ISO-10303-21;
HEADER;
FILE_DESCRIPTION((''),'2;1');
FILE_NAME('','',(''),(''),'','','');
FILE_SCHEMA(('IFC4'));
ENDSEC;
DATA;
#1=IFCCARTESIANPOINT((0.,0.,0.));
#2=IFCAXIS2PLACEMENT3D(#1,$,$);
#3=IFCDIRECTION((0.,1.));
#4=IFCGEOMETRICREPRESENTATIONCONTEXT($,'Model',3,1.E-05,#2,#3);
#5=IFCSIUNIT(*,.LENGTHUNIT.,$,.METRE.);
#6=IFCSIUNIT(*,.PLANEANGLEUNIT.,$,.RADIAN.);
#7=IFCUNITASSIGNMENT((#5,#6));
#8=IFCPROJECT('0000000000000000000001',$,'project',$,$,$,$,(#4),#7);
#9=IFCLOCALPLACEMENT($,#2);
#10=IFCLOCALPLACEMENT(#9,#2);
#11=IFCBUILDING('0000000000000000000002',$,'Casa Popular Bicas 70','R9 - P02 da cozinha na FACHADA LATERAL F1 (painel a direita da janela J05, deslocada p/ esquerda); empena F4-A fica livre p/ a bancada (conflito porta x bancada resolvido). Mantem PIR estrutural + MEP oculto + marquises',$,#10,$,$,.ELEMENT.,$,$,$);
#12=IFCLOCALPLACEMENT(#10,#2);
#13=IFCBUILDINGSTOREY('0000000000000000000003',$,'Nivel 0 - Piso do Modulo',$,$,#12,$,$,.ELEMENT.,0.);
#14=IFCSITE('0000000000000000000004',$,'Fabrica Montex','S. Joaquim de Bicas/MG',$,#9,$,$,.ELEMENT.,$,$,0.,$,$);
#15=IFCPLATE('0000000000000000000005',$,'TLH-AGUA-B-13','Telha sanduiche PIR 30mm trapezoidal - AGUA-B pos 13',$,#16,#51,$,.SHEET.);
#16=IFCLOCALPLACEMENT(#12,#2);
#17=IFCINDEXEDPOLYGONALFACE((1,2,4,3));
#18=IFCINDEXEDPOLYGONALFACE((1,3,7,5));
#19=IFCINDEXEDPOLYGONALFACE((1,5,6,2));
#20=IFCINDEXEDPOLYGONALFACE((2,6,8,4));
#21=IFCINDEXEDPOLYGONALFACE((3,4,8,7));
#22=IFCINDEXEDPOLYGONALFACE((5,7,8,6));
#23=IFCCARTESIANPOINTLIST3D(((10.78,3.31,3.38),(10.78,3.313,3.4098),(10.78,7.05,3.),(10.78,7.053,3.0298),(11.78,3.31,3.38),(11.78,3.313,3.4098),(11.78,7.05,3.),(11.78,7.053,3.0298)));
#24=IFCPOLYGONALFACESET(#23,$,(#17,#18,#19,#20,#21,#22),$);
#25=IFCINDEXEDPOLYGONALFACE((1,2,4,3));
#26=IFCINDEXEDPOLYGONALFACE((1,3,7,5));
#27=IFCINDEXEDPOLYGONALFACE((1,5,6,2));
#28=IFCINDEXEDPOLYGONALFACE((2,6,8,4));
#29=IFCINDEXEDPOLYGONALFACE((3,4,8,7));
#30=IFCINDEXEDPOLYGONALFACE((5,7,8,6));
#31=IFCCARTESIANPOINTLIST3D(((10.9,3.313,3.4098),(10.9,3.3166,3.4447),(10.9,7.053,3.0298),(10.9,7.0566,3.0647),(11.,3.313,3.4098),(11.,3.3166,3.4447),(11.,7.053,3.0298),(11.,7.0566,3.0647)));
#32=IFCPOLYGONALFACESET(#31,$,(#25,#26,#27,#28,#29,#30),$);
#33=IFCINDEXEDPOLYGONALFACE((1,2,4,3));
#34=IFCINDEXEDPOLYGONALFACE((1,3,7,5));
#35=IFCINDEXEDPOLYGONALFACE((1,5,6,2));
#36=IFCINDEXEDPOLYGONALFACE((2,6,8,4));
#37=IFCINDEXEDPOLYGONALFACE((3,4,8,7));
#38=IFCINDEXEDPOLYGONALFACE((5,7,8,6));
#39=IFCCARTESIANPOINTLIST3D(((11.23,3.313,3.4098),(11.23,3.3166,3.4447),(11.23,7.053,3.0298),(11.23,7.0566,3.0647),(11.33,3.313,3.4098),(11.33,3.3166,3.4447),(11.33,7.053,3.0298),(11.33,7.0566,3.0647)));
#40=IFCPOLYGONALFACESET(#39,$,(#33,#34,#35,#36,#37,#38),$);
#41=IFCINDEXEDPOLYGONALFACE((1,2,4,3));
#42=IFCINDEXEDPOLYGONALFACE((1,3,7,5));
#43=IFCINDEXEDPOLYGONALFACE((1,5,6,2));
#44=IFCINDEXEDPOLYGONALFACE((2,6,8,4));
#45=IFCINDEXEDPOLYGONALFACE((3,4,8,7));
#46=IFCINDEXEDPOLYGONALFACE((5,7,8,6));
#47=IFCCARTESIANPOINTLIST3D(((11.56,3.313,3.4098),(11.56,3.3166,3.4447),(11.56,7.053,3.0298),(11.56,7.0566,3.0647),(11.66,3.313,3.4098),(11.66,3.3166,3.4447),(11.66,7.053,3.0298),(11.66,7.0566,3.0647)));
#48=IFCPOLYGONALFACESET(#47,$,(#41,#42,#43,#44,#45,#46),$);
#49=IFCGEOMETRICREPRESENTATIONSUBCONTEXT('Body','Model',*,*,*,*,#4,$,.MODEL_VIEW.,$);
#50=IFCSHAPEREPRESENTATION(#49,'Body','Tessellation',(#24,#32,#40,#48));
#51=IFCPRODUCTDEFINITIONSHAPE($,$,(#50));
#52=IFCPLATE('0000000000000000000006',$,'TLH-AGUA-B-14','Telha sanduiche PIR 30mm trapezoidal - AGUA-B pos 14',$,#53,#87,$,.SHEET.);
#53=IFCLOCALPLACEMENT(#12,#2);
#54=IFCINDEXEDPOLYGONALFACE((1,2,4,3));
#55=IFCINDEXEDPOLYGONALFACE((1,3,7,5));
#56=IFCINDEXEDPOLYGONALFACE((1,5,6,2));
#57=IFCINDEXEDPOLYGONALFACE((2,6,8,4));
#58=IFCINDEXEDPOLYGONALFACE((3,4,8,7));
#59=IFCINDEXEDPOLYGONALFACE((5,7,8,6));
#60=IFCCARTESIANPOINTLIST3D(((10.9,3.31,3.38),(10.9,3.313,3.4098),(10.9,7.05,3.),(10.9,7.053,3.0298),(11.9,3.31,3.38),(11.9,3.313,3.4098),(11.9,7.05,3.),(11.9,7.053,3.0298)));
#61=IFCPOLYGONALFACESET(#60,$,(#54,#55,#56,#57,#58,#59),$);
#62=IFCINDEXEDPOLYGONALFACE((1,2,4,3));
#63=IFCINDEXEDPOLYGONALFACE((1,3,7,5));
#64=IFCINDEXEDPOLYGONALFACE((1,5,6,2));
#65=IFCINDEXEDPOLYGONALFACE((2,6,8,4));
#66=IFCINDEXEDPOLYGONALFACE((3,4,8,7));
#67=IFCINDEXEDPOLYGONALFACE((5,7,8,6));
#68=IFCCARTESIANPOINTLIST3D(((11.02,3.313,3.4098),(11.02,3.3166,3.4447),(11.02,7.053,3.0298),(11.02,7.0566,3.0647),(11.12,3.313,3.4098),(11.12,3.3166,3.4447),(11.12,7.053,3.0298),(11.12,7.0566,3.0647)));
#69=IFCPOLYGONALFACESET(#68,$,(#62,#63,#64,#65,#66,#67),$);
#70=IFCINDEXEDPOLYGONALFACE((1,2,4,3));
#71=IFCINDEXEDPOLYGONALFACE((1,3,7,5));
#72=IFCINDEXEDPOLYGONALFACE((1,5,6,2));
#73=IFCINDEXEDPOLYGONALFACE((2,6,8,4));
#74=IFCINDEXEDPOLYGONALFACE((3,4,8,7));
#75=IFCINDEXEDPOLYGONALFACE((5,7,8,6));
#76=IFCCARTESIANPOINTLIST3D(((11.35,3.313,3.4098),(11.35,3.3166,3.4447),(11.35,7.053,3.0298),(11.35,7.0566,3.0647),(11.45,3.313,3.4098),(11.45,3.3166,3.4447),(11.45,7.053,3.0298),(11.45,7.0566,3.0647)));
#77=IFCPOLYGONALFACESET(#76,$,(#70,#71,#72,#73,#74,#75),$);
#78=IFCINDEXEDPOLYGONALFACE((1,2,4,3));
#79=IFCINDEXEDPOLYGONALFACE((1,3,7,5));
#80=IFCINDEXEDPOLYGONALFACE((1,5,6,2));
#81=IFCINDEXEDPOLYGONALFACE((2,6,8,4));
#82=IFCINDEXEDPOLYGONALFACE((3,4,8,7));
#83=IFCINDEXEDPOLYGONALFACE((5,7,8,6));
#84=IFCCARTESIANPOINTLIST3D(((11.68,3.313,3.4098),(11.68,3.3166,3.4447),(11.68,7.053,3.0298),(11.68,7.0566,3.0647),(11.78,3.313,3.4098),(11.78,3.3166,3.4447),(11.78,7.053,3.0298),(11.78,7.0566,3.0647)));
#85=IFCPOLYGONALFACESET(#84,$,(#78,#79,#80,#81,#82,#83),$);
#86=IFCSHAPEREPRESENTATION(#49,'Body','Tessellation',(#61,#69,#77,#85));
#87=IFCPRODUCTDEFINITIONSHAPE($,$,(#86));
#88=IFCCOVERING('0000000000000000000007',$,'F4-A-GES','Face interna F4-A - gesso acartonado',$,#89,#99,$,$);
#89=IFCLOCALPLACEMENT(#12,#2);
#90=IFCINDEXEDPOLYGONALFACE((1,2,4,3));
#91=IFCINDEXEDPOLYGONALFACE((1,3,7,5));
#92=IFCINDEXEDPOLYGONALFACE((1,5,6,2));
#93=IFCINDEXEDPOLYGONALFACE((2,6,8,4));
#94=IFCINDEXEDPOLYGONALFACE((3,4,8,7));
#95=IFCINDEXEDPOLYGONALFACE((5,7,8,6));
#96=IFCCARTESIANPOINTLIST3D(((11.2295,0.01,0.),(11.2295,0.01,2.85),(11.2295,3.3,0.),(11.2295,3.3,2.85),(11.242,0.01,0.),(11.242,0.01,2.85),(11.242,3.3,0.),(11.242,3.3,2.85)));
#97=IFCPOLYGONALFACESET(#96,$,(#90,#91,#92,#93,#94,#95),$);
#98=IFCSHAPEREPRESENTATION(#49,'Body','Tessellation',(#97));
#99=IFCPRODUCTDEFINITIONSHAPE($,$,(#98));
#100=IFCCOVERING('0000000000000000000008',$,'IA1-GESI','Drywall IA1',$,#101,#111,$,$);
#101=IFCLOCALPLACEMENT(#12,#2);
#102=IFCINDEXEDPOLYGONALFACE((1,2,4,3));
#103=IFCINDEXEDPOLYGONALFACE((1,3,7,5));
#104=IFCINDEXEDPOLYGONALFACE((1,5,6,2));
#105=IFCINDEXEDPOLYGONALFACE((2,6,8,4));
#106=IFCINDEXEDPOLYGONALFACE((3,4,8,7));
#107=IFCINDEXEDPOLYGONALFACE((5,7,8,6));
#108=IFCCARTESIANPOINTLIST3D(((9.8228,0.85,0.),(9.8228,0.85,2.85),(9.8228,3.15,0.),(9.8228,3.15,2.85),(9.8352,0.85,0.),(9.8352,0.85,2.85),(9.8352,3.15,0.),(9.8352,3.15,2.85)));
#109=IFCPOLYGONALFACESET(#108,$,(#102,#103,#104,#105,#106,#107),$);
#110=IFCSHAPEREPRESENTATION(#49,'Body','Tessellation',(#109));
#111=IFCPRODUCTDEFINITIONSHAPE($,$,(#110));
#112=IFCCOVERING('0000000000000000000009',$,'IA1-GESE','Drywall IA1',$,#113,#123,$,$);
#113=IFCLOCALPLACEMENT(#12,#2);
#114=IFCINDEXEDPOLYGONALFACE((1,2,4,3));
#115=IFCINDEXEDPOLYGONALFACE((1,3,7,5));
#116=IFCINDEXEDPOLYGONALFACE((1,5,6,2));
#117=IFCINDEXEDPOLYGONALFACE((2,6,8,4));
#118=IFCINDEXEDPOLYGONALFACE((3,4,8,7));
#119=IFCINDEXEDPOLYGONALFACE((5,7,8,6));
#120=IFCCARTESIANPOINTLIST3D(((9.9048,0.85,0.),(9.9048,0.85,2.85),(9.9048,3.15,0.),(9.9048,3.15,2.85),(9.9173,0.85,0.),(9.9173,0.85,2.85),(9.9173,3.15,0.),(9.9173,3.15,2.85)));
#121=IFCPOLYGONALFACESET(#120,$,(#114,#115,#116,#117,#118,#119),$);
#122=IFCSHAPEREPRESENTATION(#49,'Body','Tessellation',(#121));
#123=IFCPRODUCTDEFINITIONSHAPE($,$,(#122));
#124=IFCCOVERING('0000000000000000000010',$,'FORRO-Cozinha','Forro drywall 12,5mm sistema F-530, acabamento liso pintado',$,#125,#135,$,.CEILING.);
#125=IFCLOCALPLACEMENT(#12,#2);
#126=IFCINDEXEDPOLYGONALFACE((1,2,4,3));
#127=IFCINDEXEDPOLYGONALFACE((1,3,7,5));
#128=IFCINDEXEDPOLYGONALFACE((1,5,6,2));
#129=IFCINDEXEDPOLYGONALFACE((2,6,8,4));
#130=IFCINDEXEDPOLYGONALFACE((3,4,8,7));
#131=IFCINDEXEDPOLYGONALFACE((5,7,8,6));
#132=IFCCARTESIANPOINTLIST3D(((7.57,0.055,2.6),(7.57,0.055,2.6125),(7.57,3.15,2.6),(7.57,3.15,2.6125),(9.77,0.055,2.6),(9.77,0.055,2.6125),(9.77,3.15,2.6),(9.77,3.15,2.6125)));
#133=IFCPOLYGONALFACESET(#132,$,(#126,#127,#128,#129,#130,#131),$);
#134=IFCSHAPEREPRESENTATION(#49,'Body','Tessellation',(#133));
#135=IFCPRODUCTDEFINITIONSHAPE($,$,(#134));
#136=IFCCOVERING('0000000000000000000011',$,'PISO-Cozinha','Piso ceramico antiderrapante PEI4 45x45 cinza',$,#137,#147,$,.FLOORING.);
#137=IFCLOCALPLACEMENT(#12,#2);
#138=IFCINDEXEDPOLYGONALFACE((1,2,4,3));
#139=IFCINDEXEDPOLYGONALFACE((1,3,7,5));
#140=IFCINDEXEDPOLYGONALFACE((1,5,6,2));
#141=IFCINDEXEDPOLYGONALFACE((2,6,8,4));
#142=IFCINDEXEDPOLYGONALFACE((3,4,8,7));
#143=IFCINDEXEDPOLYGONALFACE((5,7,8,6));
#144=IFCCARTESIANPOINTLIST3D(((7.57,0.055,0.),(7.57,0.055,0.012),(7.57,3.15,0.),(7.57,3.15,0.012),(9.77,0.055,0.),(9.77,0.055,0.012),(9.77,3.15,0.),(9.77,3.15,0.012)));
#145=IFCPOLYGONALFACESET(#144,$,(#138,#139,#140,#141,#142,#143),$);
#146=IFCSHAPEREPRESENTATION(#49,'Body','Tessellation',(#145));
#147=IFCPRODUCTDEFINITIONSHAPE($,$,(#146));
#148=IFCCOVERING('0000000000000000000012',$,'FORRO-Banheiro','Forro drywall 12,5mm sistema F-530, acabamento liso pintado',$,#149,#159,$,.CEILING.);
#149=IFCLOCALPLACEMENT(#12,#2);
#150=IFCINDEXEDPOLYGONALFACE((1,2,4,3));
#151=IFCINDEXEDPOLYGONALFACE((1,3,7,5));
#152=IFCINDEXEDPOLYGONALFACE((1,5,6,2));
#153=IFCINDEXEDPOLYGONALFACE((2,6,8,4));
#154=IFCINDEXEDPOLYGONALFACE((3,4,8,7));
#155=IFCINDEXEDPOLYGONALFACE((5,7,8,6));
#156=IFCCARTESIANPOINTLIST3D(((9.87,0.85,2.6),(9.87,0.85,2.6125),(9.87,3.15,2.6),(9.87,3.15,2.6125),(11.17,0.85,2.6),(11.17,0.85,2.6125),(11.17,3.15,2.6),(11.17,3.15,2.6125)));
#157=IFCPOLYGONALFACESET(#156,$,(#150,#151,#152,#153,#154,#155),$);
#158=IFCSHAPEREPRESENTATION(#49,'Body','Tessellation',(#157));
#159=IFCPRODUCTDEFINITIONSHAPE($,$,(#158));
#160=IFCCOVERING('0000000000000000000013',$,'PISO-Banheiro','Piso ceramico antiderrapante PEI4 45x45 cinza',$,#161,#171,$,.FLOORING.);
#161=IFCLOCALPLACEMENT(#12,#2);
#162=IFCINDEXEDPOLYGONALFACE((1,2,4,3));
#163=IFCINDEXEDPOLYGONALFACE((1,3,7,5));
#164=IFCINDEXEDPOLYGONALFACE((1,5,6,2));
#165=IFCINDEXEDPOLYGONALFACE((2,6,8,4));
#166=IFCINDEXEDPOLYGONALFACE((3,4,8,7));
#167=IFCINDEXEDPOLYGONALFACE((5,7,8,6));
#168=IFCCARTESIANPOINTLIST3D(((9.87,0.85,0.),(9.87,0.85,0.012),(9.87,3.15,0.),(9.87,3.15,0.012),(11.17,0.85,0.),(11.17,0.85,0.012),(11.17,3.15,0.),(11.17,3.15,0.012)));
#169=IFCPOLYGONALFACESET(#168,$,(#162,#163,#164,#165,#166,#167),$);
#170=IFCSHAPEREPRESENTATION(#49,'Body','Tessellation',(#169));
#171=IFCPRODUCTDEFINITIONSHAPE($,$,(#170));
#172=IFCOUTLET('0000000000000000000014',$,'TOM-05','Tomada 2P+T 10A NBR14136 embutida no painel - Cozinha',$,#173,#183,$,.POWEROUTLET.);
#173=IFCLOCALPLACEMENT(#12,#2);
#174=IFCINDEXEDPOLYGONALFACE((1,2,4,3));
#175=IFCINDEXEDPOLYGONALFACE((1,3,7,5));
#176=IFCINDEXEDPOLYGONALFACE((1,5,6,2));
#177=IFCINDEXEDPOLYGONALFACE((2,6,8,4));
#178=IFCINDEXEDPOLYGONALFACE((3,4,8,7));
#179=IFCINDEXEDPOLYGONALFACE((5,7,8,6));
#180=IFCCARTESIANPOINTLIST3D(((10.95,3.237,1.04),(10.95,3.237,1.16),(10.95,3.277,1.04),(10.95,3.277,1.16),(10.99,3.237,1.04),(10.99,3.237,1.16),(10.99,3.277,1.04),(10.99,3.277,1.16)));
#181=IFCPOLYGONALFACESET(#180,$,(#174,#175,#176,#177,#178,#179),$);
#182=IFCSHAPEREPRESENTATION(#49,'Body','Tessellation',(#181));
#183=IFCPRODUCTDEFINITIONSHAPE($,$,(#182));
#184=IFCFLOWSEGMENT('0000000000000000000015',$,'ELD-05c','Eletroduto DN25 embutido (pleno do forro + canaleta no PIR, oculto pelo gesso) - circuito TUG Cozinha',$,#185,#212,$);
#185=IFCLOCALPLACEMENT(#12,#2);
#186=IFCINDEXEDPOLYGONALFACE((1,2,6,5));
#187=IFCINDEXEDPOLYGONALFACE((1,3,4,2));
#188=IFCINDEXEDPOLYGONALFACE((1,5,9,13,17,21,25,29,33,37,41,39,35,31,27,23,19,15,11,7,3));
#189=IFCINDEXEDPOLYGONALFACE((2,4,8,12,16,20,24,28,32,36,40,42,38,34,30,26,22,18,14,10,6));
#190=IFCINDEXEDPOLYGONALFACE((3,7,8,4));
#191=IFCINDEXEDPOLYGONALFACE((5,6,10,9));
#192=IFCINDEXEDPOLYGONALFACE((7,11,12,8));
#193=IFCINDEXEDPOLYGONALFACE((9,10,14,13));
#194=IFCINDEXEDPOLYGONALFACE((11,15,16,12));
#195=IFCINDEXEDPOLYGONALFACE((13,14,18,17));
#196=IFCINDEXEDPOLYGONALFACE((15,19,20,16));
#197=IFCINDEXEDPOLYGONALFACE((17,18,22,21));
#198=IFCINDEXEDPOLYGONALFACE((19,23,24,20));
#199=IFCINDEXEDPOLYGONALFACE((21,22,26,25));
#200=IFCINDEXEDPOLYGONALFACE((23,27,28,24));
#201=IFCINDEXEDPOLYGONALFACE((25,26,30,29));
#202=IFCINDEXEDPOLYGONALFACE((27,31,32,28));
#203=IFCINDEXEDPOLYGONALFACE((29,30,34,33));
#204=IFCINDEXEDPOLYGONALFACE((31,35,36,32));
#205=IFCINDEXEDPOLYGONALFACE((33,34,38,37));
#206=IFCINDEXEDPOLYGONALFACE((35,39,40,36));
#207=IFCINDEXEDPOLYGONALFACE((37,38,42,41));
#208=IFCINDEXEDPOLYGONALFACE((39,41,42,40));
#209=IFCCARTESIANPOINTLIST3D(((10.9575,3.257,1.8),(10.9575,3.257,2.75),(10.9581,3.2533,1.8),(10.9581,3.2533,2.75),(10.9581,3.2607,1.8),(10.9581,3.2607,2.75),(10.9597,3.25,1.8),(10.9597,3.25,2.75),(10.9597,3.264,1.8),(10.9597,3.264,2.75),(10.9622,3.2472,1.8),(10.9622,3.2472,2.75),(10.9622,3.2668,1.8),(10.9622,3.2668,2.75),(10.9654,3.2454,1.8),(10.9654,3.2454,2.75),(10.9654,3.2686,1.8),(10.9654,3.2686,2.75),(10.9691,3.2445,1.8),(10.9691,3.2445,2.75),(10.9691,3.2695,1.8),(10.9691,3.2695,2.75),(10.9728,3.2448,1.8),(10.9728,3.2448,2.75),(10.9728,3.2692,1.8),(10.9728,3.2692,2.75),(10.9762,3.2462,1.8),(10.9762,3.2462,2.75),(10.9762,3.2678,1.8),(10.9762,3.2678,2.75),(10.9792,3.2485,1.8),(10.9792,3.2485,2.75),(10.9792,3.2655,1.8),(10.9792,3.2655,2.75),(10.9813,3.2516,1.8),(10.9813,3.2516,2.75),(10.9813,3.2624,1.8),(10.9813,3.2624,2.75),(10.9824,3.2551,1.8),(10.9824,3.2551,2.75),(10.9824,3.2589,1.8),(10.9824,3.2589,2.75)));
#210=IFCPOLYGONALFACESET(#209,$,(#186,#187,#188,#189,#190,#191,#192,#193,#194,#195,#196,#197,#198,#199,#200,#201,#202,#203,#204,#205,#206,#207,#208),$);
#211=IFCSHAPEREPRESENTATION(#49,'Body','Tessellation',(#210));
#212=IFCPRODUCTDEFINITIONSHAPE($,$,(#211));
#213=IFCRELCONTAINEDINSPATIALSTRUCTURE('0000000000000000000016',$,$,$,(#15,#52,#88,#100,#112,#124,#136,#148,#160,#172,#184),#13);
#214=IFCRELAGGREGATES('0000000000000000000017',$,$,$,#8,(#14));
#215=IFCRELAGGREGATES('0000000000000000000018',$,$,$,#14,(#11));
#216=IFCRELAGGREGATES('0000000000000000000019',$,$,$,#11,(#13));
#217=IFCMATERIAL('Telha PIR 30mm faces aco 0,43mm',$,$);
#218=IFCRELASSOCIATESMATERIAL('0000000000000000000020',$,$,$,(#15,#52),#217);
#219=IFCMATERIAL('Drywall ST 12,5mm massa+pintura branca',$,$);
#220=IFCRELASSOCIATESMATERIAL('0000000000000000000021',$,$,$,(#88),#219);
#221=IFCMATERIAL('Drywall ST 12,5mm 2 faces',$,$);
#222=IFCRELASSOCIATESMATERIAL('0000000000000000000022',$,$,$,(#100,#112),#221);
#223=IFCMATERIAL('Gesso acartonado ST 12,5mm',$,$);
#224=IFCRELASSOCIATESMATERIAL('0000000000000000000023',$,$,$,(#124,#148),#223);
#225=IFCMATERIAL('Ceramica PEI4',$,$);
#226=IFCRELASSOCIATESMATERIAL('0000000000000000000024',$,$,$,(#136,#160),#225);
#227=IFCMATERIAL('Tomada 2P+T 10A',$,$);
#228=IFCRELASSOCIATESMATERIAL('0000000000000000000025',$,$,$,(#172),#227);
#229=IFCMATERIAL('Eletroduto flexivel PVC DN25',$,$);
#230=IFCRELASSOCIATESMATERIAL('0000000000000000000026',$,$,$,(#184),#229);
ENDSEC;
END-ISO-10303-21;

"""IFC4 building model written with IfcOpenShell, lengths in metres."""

from ifc_helpers import new_model, si_unit, direction, frame, frame_2d, origin, origin_2d, place, context, subcontext, project, spatial, rectangle, circle, extrude, material, element, save


model = new_model("IFC4")

# Units and contexts
model_context = context("Model", 3, precision=1e-05, world=origin(), true_north=direction((0.0, 1.0)))
body_context = subcontext(model_context, "Body", "Model", "MODEL_VIEW")
ifc_project = project(units=[si_unit("LENGTHUNIT", "METRE"), si_unit("PLANEANGLEUNIT", "RADIAN")], contexts=[model_context])

# Site, building, storey
site_placement = place(None, origin())
site = spatial("IfcSite", under=ifc_project, at=site_placement, Name="Fabrica Montex", Description="S. Joaquim de Bicas/MG", CompositionType="ELEMENT", RefElevation=0.0)
building_placement = place(site_placement, origin())
building = spatial("IfcBuilding", under=site, at=building_placement, Name="Casa Popular Bicas 70", Description="R9 - P02 da cozinha na FACHADA LATERAL F1 (painel a direita da janela J05, deslocada p/ esquerda); empena F4-A fica livre p/ a bancada (conflito porta x bancada resolvido). Mantem PIR estrutural + MEP oculto + marquises", CompositionType="ELEMENT")
storey_placement = place(building_placement, origin())
storey = spatial("IfcBuildingStorey", under=building, at=storey_placement, Name="Nivel 0 - Piso do Modulo", CompositionType="ELEMENT", Elevation=0.0)

# Plates
ifc_material_1 = material(Name="Telha PIR 30mm faces aco 0,43mm")
for number, where, z_axis, x_axis, name, description in (
    (1, (10.78, 3.31, 3.38), (0.0, 0.101084, 0.994878), (1.0, 0.0, 0.0), "TLH-AGUA-B-13", "Telha sanduiche PIR 30mm trapezoidal - AGUA-B pos 13"),
    (2, (10.9, 3.31, 3.38), (0.0, 0.101084, 0.994878), (1.0, 0.0, 0.0), "TLH-AGUA-B-14", "Telha sanduiche PIR 30mm trapezoidal - AGUA-B pos 14"),
):
    element("IfcPlate", number, at=place(storey_placement, frame(where, z_axis=z_axis, x_axis=x_axis)), inside=storey, material=ifc_material_1, Name=name, Description=description, PredefinedType="SHEET", context=body_context, shape_type="SweptSolid", body=[
        extrude(rectangle(XDim=1.0, YDim=3.7593, at=frame_2d((0.5, 1.8796))), origin(), (0.0, 0.0, 1.0), 0.03),
        extrude(rectangle(XDim=0.1, YDim=3.7593, at=frame_2d((0.17, 1.8796))), frame((0.0, 0.0, 0.03)), (0.0, 0.0, 1.0), 0.035),
        extrude(rectangle(XDim=0.1, YDim=3.7593, at=frame_2d((0.5, 1.8796))), frame((0.0, 0.0, 0.03)), (0.0, 0.0, 1.0), 0.035),
        extrude(rectangle(XDim=0.1, YDim=3.7593, at=frame_2d((0.83, 1.8796))), frame((0.0, 0.0, 0.03)), (0.0, 0.0, 1.0), 0.035),
    ])

# Coverings
ifc_material_2 = material(Name="Drywall ST 12,5mm massa+pintura branca")
covering_1_placement = place(None, frame((11.2357, 3.3, 0.0), z_axis=(0.0, 0.0, 1.0), x_axis=(0.0, -1.0, 0.0)))
element("IfcCovering", 3, at=covering_1_placement, inside=storey, material=ifc_material_2, Name="F4-A-GES", Description="Face interna F4-A - gesso acartonado", context=body_context, shape_type="SweptSolid", body=[
    extrude(rectangle(XDim=3.29, YDim=0.0125, at=frame_2d((1.645, 0.0))), origin(), (0.0, 0.0, 1.0), 2.85),
])
ifc_material_3 = material(Name="Drywall ST 12,5mm 2 faces")
for number, where, z_axis, x_axis, name in (
    (4, (9.829, 3.15, 0.0), (0.0, 0.0, 1.0), (0.0, -1.0, 0.0), "IA1-GESI"),
    (5, (9.911, 3.15, 0.0), (0.0, 0.0, 1.0), (0.0, -1.0, 0.0), "IA1-GESE"),
):
    element("IfcCovering", number, at=place(None, frame(where, z_axis=z_axis, x_axis=x_axis)), inside=storey, material=ifc_material_3, Name=name, Description="Drywall IA1", context=body_context, shape_type="SweptSolid", body=[
        extrude(rectangle(XDim=2.3, YDim=0.0125, at=frame_2d((1.15, 0.0))), origin(), (0.0, 0.0, 1.0), 2.85),
    ])
ifc_material_4 = material(Name="Gesso acartonado ST 12,5mm")
covering_2_placement = place(None, frame((9.77, 3.15, 2.6), z_axis=(0.0, 0.0, 1.0), x_axis=(-1.0, 0.0, 0.0)))
element("IfcCovering", 6, at=covering_2_placement, inside=storey, material=ifc_material_4, Name="FORRO-Cozinha", Description="Forro drywall 12,5mm sistema F-530, acabamento liso pintado", PredefinedType="CEILING", context=body_context, shape_type="SweptSolid", body=[
    extrude(rectangle(XDim=2.2, YDim=3.095, at=frame_2d((1.1, 1.5475))), origin(), (0.0, 0.0, 1.0), 0.0125),
])
ifc_material_5 = material(Name="Ceramica PEI4")
covering_3_placement = place(None, frame((9.77, 3.15, 0.0), z_axis=(0.0, 0.0, 1.0), x_axis=(-1.0, 0.0, 0.0)))
element("IfcCovering", 7, at=covering_3_placement, inside=storey, material=ifc_material_5, Name="PISO-Cozinha", Description="Piso ceramico antiderrapante PEI4 45x45 cinza", PredefinedType="FLOORING", context=body_context, shape_type="SweptSolid", body=[
    extrude(rectangle(XDim=2.2, YDim=3.095, at=frame_2d((1.1, 1.5475))), origin(), (0.0, 0.0, 1.0), 0.012),
])
covering_4_placement = place(None, frame((11.17, 3.15, 2.6), z_axis=(0.0, 0.0, 1.0), x_axis=(-1.0, 0.0, 0.0)))
element("IfcCovering", 8, at=covering_4_placement, inside=storey, material=ifc_material_4, Name="FORRO-Banheiro", Description="Forro drywall 12,5mm sistema F-530, acabamento liso pintado", PredefinedType="CEILING", context=body_context, shape_type="SweptSolid", body=[
    extrude(rectangle(XDim=1.3, YDim=2.3, at=frame_2d((0.65, 1.15))), origin(), (0.0, 0.0, 1.0), 0.0125),
])
covering_5_placement = place(None, frame((11.17, 3.15, 0.0), z_axis=(0.0, 0.0, 1.0), x_axis=(-1.0, 0.0, 0.0)))
element("IfcCovering", 9, at=covering_5_placement, inside=storey, material=ifc_material_5, Name="PISO-Banheiro", Description="Piso ceramico antiderrapante PEI4 45x45 cinza", PredefinedType="FLOORING", context=body_context, shape_type="SweptSolid", body=[
    extrude(rectangle(XDim=1.3, YDim=2.3, at=frame_2d((0.65, 1.15))), origin(), (0.0, 0.0, 1.0), 0.012),
])

# Outlet
ifc_material_6 = material(Name="Tomada 2P+T 10A")
outlet_1_placement = place(None, frame((10.99, 3.277, 1.04), z_axis=(0.0, 0.0, 1.0), x_axis=(-1.0, 0.0, 0.0)))
element("IfcOutlet", 10, at=outlet_1_placement, inside=storey, material=ifc_material_6, Name="TOM-05", Description="Tomada 2P+T 10A NBR14136 embutida no painel - Cozinha", PredefinedType="POWEROUTLET", context=body_context, shape_type="SweptSolid", body=[
    extrude(rectangle(XDim=0.04, YDim=0.04, at=frame_2d((0.02, 0.02))), origin(), (0.0, 0.0, 1.0), 0.12),
])

# Flow segment
ifc_material_7 = material(Name="Eletroduto flexivel PVC DN25")
flow_segment_1_placement = place(None, frame((10.97, 3.257, 2.75), z_axis=(0.0, 0.0, -1.0), x_axis=(-1.0, 0.0, 0.0)))
element("IfcFlowSegment", 11, at=flow_segment_1_placement, inside=storey, material=ifc_material_7, Name="ELD-05c", Description="Eletroduto DN25 embutido (pleno do forro + canaleta no PIR, oculto pelo gesso) - circuito TUG Cozinha", context=body_context, shape_type="SweptSolid", body=[
    extrude(circle(Radius=0.0125, at=origin_2d()), origin(), (0.0, 0.0, 1.0), 0.95),
])

save(model, "model.ifc")
